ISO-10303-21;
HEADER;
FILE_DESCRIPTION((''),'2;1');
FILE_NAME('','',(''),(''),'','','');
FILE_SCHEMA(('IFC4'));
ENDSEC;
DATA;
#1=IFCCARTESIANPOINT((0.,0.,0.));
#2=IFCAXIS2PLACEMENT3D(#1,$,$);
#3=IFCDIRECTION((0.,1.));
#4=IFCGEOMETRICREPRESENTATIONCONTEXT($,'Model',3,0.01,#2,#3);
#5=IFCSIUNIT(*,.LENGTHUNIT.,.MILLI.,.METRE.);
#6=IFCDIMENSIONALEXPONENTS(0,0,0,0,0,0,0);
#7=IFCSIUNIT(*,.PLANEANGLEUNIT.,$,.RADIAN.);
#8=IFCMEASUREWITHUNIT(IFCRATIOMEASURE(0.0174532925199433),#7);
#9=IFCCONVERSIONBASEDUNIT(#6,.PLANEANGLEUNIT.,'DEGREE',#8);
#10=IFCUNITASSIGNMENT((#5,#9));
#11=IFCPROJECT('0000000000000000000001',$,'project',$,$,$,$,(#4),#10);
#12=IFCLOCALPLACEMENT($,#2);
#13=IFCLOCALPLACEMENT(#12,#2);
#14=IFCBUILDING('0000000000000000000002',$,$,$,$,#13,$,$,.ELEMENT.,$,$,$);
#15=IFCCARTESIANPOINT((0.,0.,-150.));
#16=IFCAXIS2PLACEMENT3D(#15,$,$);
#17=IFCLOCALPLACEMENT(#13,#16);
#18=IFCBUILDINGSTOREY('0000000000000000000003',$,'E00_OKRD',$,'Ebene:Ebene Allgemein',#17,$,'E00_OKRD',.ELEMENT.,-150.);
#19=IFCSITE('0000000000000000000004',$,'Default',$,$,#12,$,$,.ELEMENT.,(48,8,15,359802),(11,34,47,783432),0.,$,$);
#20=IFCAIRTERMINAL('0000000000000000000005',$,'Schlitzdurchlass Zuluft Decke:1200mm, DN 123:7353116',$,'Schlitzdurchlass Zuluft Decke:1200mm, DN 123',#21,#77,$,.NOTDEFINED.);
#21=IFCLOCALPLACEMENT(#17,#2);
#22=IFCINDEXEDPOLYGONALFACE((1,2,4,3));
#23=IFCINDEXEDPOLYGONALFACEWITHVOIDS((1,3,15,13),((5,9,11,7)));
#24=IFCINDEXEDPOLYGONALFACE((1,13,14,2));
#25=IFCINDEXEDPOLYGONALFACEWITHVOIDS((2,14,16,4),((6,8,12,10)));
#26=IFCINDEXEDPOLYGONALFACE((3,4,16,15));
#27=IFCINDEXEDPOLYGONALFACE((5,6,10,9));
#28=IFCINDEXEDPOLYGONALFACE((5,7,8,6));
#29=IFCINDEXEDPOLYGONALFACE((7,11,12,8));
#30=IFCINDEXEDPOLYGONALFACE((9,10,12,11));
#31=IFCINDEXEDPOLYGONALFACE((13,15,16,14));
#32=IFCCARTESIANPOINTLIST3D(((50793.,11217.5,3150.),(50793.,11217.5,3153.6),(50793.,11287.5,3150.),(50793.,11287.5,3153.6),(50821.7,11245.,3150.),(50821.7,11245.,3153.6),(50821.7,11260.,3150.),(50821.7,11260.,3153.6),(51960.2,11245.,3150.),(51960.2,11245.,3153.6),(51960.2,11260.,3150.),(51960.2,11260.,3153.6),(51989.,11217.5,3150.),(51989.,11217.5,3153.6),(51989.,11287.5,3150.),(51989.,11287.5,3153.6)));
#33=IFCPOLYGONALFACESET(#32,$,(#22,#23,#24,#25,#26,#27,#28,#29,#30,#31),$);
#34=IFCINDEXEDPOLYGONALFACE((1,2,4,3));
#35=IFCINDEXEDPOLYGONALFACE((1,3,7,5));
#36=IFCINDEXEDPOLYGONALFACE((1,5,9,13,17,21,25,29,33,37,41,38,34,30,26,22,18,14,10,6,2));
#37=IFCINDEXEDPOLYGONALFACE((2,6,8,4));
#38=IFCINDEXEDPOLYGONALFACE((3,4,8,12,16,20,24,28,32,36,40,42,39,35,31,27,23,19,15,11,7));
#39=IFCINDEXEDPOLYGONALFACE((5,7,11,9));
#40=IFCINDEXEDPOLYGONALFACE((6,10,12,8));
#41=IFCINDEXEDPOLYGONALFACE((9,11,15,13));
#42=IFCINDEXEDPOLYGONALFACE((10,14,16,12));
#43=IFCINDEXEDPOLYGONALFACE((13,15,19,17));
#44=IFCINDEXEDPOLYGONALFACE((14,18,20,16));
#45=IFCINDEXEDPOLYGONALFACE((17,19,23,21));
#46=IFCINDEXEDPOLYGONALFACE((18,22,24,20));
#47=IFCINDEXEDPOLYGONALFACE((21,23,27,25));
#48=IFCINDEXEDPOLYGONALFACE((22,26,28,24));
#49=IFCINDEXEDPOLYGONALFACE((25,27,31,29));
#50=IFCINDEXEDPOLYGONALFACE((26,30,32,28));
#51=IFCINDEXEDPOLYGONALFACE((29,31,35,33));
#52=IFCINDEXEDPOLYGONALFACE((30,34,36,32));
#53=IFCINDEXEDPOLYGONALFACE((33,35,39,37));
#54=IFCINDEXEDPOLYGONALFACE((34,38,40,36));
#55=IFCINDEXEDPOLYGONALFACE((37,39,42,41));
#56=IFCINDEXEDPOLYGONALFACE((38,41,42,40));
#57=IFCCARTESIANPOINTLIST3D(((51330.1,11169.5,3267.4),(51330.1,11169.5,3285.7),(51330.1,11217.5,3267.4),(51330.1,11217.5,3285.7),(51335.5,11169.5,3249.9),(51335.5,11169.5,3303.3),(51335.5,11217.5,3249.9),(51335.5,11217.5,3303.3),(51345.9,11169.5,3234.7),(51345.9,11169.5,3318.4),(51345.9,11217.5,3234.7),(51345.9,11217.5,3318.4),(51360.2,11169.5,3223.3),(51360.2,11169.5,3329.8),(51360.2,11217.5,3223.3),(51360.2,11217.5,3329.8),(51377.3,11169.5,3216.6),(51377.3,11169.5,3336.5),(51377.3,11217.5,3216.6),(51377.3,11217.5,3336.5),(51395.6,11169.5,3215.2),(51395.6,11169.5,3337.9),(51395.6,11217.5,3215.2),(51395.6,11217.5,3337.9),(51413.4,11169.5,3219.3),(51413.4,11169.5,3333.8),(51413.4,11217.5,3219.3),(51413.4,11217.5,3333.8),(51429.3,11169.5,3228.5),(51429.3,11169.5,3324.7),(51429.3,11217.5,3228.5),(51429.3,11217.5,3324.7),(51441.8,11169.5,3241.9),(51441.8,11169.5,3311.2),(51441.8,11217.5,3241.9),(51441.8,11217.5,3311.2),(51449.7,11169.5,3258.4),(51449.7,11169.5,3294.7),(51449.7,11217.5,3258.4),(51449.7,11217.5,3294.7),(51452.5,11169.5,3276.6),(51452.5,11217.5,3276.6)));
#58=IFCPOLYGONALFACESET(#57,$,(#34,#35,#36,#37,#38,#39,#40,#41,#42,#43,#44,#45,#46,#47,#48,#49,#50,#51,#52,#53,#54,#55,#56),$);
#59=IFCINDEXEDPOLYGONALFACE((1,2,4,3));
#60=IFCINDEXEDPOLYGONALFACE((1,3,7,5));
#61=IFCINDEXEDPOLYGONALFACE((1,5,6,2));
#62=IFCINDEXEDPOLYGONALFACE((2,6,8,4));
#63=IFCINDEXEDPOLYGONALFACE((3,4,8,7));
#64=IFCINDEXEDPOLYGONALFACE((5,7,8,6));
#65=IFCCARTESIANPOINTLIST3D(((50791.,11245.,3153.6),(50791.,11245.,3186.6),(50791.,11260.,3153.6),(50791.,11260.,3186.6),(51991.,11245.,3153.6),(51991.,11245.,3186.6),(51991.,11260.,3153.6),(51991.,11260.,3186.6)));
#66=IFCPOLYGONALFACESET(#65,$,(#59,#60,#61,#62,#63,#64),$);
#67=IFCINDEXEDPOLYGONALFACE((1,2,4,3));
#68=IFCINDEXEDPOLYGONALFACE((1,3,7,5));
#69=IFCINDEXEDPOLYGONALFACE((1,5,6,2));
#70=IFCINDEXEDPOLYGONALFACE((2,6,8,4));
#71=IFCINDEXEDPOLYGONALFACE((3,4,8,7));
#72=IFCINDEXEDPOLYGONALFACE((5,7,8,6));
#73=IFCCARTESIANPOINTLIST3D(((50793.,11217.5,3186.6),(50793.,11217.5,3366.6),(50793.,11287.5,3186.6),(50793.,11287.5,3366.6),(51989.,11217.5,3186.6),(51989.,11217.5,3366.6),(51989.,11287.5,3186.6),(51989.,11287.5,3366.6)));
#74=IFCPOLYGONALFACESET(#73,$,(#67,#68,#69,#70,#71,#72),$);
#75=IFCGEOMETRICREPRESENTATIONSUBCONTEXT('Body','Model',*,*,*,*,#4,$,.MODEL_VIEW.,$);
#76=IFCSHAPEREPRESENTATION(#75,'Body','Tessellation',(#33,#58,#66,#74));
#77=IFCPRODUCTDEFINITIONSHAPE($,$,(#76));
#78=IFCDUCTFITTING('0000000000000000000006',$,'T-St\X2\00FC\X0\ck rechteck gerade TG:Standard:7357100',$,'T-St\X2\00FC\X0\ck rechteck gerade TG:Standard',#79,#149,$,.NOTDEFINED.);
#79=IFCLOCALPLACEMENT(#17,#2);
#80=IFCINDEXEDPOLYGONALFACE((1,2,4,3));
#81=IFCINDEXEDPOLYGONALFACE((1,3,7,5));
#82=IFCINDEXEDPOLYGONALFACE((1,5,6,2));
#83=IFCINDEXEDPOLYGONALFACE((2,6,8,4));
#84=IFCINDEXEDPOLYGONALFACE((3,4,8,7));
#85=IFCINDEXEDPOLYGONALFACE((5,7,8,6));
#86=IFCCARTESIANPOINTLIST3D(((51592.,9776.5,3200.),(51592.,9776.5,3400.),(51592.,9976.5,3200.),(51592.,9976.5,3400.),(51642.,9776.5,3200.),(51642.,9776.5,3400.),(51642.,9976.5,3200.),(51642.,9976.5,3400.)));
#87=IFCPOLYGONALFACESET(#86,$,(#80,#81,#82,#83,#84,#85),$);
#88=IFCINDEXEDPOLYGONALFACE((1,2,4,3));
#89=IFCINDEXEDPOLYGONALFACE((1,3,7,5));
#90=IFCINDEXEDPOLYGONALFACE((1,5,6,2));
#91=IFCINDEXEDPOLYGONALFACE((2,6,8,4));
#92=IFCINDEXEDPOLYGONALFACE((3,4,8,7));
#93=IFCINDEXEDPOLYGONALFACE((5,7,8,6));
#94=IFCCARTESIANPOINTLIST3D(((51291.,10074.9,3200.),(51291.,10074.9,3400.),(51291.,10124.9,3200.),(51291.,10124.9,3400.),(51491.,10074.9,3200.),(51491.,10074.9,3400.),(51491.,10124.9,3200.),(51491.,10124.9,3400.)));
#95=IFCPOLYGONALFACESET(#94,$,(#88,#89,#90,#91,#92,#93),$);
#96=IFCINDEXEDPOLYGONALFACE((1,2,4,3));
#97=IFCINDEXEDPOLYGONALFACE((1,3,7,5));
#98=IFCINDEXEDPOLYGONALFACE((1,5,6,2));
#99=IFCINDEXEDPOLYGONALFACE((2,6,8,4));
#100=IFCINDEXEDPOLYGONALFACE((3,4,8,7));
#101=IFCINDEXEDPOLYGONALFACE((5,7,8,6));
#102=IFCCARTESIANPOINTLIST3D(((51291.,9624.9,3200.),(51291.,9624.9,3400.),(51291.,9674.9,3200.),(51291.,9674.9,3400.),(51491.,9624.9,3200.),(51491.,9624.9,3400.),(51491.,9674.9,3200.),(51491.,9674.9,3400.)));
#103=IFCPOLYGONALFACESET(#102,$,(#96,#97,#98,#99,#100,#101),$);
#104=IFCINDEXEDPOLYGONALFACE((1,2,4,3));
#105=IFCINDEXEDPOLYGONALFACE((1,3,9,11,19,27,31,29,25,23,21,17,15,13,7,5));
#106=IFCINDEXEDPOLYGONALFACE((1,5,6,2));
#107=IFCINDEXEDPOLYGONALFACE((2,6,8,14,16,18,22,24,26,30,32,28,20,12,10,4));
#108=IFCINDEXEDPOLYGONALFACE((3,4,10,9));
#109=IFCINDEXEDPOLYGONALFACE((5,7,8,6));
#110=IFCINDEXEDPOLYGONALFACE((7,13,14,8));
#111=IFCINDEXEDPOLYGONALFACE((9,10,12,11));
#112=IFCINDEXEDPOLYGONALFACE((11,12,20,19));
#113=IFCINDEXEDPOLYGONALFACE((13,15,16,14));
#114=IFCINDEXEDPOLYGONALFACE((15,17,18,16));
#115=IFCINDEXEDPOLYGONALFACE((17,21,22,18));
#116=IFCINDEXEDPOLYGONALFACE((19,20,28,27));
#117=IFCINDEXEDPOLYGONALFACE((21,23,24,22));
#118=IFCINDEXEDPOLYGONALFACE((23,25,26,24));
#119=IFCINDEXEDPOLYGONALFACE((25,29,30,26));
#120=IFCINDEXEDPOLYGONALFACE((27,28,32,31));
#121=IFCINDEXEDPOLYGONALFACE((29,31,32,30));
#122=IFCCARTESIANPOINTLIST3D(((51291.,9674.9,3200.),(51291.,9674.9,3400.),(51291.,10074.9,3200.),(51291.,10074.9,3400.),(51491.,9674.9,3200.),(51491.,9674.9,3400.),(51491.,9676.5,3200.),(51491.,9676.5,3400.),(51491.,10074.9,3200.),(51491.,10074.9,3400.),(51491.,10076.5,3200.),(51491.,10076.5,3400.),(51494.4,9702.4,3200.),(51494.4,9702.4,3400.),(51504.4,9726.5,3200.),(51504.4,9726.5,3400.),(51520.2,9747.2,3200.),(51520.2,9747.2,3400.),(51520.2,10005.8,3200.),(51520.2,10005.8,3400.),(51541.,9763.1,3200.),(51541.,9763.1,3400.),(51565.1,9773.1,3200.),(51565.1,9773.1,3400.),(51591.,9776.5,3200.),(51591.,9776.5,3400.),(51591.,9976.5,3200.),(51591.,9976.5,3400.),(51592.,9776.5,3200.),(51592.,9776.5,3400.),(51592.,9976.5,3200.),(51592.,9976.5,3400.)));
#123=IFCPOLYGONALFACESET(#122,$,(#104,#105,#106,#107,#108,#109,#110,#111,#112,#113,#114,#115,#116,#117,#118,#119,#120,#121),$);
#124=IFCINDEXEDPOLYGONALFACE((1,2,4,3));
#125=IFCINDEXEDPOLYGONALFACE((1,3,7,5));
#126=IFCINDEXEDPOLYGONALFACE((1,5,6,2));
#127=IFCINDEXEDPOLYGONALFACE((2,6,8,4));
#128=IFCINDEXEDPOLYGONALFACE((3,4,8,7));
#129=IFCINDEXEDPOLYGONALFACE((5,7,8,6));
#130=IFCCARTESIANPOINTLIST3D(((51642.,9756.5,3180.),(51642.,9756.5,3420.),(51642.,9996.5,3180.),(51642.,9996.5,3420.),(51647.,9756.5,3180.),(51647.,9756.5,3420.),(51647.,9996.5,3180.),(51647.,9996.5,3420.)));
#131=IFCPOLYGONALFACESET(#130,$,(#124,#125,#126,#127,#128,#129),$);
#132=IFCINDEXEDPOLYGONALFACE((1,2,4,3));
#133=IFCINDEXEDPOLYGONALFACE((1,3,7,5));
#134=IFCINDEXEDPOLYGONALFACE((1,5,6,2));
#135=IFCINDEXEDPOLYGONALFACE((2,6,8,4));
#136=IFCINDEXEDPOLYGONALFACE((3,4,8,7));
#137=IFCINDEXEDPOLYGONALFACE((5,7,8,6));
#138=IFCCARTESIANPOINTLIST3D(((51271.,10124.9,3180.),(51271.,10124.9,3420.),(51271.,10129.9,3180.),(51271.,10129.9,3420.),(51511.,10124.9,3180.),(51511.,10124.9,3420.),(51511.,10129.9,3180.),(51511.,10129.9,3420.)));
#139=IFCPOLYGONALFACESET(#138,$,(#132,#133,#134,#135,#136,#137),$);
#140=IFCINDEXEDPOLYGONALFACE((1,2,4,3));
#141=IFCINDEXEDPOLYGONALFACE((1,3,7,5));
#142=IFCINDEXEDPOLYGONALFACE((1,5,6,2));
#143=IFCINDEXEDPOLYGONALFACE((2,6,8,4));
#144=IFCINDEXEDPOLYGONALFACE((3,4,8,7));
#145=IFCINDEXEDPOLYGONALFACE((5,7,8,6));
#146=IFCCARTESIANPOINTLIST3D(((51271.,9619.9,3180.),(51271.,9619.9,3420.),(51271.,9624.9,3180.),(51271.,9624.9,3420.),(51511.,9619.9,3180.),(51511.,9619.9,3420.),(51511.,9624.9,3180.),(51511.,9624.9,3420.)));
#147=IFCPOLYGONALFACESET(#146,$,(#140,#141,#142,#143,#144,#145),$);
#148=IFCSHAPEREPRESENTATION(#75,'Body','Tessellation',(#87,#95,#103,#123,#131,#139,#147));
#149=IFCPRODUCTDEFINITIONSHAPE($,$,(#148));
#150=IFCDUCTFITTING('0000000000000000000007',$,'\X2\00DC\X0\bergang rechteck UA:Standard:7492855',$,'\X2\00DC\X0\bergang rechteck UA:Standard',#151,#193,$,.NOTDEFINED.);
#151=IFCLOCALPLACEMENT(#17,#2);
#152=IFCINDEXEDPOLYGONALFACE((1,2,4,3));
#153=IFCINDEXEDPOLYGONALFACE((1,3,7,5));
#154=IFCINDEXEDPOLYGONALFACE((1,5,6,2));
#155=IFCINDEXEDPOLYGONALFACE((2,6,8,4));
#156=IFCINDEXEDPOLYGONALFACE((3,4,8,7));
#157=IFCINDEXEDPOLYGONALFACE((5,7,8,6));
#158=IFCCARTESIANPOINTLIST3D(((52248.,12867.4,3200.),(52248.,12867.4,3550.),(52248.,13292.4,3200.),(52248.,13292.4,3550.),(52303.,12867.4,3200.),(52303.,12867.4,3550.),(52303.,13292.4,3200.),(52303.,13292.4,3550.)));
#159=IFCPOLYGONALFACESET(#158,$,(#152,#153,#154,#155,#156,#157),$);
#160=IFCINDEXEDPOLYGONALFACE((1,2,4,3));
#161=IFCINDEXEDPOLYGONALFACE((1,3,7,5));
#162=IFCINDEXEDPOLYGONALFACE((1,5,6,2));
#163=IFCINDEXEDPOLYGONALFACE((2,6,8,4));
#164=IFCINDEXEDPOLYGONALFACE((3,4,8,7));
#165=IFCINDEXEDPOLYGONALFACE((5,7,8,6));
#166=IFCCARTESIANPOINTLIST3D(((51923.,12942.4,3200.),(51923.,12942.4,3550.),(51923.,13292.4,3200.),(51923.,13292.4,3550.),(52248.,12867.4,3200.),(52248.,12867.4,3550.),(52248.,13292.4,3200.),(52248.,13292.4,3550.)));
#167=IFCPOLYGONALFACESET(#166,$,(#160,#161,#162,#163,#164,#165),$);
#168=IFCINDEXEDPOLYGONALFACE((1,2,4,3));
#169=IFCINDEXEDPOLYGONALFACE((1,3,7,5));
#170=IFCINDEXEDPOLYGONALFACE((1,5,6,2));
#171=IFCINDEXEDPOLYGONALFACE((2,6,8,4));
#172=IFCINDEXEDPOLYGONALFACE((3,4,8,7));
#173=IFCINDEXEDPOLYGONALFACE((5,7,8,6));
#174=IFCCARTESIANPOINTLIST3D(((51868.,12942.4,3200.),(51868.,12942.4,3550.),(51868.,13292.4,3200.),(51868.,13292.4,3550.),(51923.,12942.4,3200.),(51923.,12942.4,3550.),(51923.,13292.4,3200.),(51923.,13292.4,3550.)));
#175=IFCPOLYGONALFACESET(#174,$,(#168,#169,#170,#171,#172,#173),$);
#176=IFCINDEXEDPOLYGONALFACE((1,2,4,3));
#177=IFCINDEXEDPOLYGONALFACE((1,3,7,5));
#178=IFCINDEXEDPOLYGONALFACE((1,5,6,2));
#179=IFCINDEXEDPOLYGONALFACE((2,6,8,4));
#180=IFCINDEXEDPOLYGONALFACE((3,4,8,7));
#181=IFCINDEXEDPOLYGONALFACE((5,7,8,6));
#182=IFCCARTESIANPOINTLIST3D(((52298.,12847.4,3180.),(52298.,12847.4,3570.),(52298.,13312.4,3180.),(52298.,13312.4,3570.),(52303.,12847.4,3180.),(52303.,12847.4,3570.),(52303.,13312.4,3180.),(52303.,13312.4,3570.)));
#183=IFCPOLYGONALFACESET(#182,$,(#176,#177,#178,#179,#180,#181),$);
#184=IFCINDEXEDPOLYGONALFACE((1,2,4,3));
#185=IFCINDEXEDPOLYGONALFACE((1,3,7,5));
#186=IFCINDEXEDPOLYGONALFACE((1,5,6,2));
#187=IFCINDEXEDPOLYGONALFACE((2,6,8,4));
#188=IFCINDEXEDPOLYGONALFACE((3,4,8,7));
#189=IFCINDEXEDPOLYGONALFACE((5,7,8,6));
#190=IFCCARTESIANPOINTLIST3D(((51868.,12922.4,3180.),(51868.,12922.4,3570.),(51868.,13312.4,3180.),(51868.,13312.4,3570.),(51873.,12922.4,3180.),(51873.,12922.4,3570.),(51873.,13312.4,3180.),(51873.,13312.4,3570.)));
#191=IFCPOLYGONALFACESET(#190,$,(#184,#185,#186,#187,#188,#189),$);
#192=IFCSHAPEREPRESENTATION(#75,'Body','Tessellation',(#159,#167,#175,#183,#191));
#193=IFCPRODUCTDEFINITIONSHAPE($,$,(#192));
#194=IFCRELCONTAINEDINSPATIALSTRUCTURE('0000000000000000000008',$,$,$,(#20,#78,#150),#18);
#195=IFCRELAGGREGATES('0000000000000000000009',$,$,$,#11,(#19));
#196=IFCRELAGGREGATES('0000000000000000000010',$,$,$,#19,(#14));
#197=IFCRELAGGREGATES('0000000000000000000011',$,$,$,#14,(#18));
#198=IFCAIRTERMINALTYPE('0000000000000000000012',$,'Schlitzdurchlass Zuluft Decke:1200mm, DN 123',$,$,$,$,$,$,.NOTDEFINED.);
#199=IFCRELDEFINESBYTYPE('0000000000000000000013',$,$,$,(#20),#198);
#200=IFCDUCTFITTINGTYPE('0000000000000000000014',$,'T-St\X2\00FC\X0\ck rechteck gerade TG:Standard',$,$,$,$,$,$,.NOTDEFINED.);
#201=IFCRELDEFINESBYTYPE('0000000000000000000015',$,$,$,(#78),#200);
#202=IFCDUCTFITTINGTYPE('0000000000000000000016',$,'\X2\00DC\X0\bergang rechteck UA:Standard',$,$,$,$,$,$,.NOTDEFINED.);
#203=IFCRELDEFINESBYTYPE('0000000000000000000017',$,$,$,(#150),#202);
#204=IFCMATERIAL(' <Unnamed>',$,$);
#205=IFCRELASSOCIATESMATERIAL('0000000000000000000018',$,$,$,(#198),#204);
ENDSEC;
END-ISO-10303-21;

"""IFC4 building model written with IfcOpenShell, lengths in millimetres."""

from ifc_helpers import new_model, entity, si_unit, converted_unit, direction, frame, frame_2d, origin, origin_2d_with_axis, place, context, subcontext, project, spatial, polyline, circle_curve, parameter, trimmed, segment, composite_curve, rectangle, circle, outline, extrude, source, transform, mapped, material, type_object, type_shapes, element, save


model = new_model("IFC4")

# Units and contexts
model_context = context("Model", 3, precision=0.01, world=origin(), true_north=direction((0.0, 1.0)))
body_context = subcontext(model_context, "Body", "Model", "MODEL_VIEW")
ifc_project = project(units=[si_unit("LENGTHUNIT", "METRE", prefix="MILLI"), converted_unit("PLANEANGLEUNIT", "DEGREE", entity("IfcRatioMeasure", 0.0174532925199433), si_unit("PLANEANGLEUNIT", "RADIAN"), dimensions=[0, 0, 0, 0, 0, 0, 0])], contexts=[model_context])

# Site, building, storey
site_placement = place(None, origin())
site = spatial("IfcSite", under=ifc_project, at=site_placement, Name="Default", CompositionType="ELEMENT", RefLatitude=(48, 8, 15, 359802), RefLongitude=(11, 34, 47, 783432), RefElevation=0.0)
building_placement = place(site_placement, origin())
building = spatial("IfcBuilding", under=site, at=building_placement, CompositionType="ELEMENT")
storey_placement = place(building_placement, frame((0.0, 0.0, -150.0)))
storey = spatial("IfcBuildingStorey", under=building, at=storey_placement, Name="E00_OKRD", ObjectType="Ebene:Ebene Allgemein", LongName="E00_OKRD", CompositionType="ELEMENT", Elevation=-150.0)

# Shared definitions
ifc_material_1 = material(Name=" <Unnamed>")

# Air terminal
air_terminal_type_1 = type_object("IfcAirTerminalType", Name="Schlitzdurchlass Zuluft Decke:1200mm, DN 123", PredefinedType="NOTDEFINED", material=ifc_material_1)
shared_shape_1 = source(origin(), body_context, "Body", "SweptSolid", [
    extrude(outline(polyline([(-598.0, -35.0), (598.0, -35.0), (598.0, 35.0), (-598.0, 35.0), (-598.0, -35.0)]), holes=[polyline([(-569.2, -7.5), (-569.2, 7.5), (569.2, 7.5), (569.2, -7.5), (-569.2, -7.5)])]), frame((600.0, 35.0, 0.0), z_axis=(0.0, 0.0, 1.0), x_axis=(-1.0, 0.0, 0.0)), (0.0, 0.0, 1.0), 3.6),
    extrude(circle(Radius=61.5, at=frame_2d((0.0, 0.0), x_axis=(1.0, 0.0))), frame((600.0, 70.0, 126.6), z_axis=(0.0, 1.0, 0.0), x_axis=(-1.0, 0.0, 0.0)), (0.0, 0.0, 1.0), 48.0),
    extrude(rectangle(XDim=1200.0, YDim=15.0, at=origin_2d_with_axis()), frame((600.0, 35.0, 3.6), z_axis=(0.0, 0.0, 1.0), x_axis=(-1.0, 0.0, 0.0)), (0.0, 0.0, 1.0), 33.0),
    extrude(rectangle(XDim=1196.0, YDim=70.0, at=origin_2d_with_axis()), frame((600.0, 35.0, 36.6), z_axis=(0.0, 0.0, 1.0), x_axis=(-1.0, 0.0, 0.0)), (0.0, 0.0, 1.0), 180.0),
])
type_shapes(air_terminal_type_1, [shared_shape_1])
air_terminal_1_placement = place(storey_placement, frame((51991.0, 11287.5, 3150.0), z_axis=(0.0, 0.0, 1.0), x_axis=(-1.0, 0.0, 0.0)))
element("IfcAirTerminal", 1, at=air_terminal_1_placement, inside=storey, type_object=air_terminal_type_1, Name="Schlitzdurchlass Zuluft Decke:1200mm, DN 123:7353116", ObjectType="Schlitzdurchlass Zuluft Decke:1200mm, DN 123", PredefinedType="NOTDEFINED", context=body_context, shape_type="MappedRepresentation", body=[
    mapped(shared_shape_1, transform((0.0, 0.0, 0.0), scale=1.0)),
])

# Duct fittings
duct_fitting_type_1 = type_object("IfcDuctFittingType", Name="T-Stück rechteck gerade TG:Standard", PredefinedType="NOTDEFINED")
shared_shape_2 = source(origin(), body_context, "Body", "SweptSolid", [
    extrude(rectangle(XDim=50.0, YDim=200.0, at=frame_2d((0.0, 0.0), x_axis=(1.0, 0.0))), frame((0.0, -226.0, -100.0), z_axis=(0.0, 0.0, 1.0), x_axis=(0.0, -1.0, 0.0)), (0.0, 0.0, 1.0), 200.0),
    extrude(rectangle(XDim=50.0, YDim=200.0, at=frame_2d((0.0, 0.0), x_axis=(1.0, 0.0))), frame((223.4, 0.0, -100.0), z_axis=(0.0, 0.0, 1.0), x_axis=(-1.0, 0.0, 0.0)), (0.0, 0.0, 1.0), 200.0),
    extrude(rectangle(XDim=50.0, YDim=200.0, at=frame_2d((0.0, 0.0), x_axis=(1.0, 0.0))), frame((-226.6, 0.0, -100.0)), (0.0, 0.0, 1.0), 200.0),
    extrude(outline(composite_curve([segment(trimmed(circle_curve(frame_2d((-200.6, -99.8), x_axis=(-1.0, 0.0)), 100.0), [parameter(180.0)], [parameter(270.0)], True, "PARAMETER"), False, "CONTINUOUS"), segment(polyline([(-100.6, -99.8), (-100.6, -100.8)]), True, "CONTINUOUS"), segment(polyline([(-100.6, -100.8), (99.4, -100.8)]), True, "CONTINUOUS"), segment(polyline([(99.4, -100.8), (99.4, -99.8)]), True, "CONTINUOUS"), segment(trimmed(circle_curve(frame_2d((199.4, -99.8), x_axis=(-1.0, 0.0)), 100.0), [parameter(270.0)], [parameter(0.0)], True, "PARAMETER"), False, "CONTINUOUS"), segment(polyline([(199.4, 0.2), (201.0, 0.2)]), True, "CONTINUOUS"), segment(polyline([(201.0, 0.2), (201.0, 200.2)]), True, "CONTINUOUS"), segment(polyline([(201.0, 200.2), (-199.0, 200.2)]), True, "CONTINUOUS"), segment(polyline([(-199.0, 200.2), (-199.0, 0.2)]), True, "CONTINUOUS"), segment(polyline([(-199.0, 0.2), (-200.6, 0.2)]), True, "CONTINUOUS")], self_intersect=False)), frame((-0.6, -100.2, -100.0), z_axis=(0.0, 0.0, -1.0), x_axis=(-1.0, 0.0, 0.0)), (0.0, 0.0, -1.0), 200.0),
    extrude(rectangle(XDim=5.0, YDim=240.0, at=frame_2d((0.0, 0.0), x_axis=(1.0, 0.0))), frame((0.0, -253.5, -120.0), z_axis=(0.0, 0.0, 1.0), x_axis=(0.0, 1.0, 0.0)), (0.0, 0.0, 1.0), 240.0),
    extrude(rectangle(XDim=5.0, YDim=240.0, at=origin_2d_with_axis()), frame((250.9, 0.0, -120.0), z_axis=(0.0, 0.0, 1.0), x_axis=(-1.0, 0.0, 0.0)), (0.0, 0.0, 1.0), 240.0),
    extrude(rectangle(XDim=5.0, YDim=240.0, at=origin_2d_with_axis()), frame((-254.1, 0.0, -120.0), z_axis=(0.0, 0.0, 1.0), x_axis=(-1.0, 0.0, 0.0)), (0.0, 0.0, 1.0), 240.0),
])
type_shapes(duct_fitting_type_1, [shared_shape_2])
duct_fitting_1_placement = place(storey_placement, frame((51391.0, 9876.5, 3300.0), z_axis=(0.0, 0.0, 1.0), x_axis=(0.0, 1.0, 0.0)))
element("IfcDuctFitting", 2, at=duct_fitting_1_placement, inside=storey, type_object=duct_fitting_type_1, Name="T-Stück rechteck gerade TG:Standard:7357100", ObjectType="T-Stück rechteck gerade TG:Standard", PredefinedType="NOTDEFINED", context=body_context, shape_type="MappedRepresentation", body=[
    mapped(shared_shape_2, transform((0.0, 0.0, 0.0), scale=1.0)),
])
duct_fitting_type_2 = type_object("IfcDuctFittingType", Name="Übergang rechteck UA:Standard", PredefinedType="NOTDEFINED")
shared_shape_3 = source(origin(), body_context, "Body", "SweptSolid", [
    extrude(rectangle(XDim=55.0, YDim=425.0, at=frame_2d((0.0, 0.0), x_axis=(1.0, 0.0))), frame((407.5, -37.5, -175.0)), (0.0, 0.0, 1.0), 350.0),
    extrude(outline(polyline([(-123.2, -188.8), (210.3, -188.8), (114.8, 225.3), (-201.9, 152.2), (-123.2, -188.8)])), frame((217.5, -18.8, -175.0), z_axis=(0.0, 0.0, 1.0), x_axis=(0.974391, -0.22486, 0.0)), (0.0, 0.0, 1.0), 350.0),
    extrude(rectangle(XDim=55.0, YDim=350.0, at=frame_2d((0.0, 0.0), x_axis=(1.0, 0.0))), frame((27.5, 0.0, -175.0)), (0.0, 0.0, 1.0), 350.0),
    extrude(rectangle(XDim=5.0, YDim=465.0, at=origin_2d_with_axis()), frame((432.5, -37.5, -195.0)), (0.0, 0.0, 1.0), 390.0),
    extrude(rectangle(XDim=5.0, YDim=390.0, at=frame_2d((0.0, 0.0), x_axis=(1.0, 0.0))), frame((2.5, 0.0, -195.0)), (0.0, 0.0, 1.0), 390.0),
])
type_shapes(duct_fitting_type_2, [shared_shape_3])
duct_fitting_2_placement = place(storey_placement, frame((51868.0, 13117.4, 3375.0)))
element("IfcDuctFitting", 3, at=duct_fitting_2_placement, inside=storey, type_object=duct_fitting_type_2, Name="Übergang rechteck UA:Standard:7492855", ObjectType="Übergang rechteck UA:Standard", PredefinedType="NOTDEFINED", context=body_context, shape_type="MappedRepresentation", body=[
    mapped(shared_shape_3, transform((0.0, 0.0, 0.0), scale=1.0)),
])

save(model, "model.ifc")
